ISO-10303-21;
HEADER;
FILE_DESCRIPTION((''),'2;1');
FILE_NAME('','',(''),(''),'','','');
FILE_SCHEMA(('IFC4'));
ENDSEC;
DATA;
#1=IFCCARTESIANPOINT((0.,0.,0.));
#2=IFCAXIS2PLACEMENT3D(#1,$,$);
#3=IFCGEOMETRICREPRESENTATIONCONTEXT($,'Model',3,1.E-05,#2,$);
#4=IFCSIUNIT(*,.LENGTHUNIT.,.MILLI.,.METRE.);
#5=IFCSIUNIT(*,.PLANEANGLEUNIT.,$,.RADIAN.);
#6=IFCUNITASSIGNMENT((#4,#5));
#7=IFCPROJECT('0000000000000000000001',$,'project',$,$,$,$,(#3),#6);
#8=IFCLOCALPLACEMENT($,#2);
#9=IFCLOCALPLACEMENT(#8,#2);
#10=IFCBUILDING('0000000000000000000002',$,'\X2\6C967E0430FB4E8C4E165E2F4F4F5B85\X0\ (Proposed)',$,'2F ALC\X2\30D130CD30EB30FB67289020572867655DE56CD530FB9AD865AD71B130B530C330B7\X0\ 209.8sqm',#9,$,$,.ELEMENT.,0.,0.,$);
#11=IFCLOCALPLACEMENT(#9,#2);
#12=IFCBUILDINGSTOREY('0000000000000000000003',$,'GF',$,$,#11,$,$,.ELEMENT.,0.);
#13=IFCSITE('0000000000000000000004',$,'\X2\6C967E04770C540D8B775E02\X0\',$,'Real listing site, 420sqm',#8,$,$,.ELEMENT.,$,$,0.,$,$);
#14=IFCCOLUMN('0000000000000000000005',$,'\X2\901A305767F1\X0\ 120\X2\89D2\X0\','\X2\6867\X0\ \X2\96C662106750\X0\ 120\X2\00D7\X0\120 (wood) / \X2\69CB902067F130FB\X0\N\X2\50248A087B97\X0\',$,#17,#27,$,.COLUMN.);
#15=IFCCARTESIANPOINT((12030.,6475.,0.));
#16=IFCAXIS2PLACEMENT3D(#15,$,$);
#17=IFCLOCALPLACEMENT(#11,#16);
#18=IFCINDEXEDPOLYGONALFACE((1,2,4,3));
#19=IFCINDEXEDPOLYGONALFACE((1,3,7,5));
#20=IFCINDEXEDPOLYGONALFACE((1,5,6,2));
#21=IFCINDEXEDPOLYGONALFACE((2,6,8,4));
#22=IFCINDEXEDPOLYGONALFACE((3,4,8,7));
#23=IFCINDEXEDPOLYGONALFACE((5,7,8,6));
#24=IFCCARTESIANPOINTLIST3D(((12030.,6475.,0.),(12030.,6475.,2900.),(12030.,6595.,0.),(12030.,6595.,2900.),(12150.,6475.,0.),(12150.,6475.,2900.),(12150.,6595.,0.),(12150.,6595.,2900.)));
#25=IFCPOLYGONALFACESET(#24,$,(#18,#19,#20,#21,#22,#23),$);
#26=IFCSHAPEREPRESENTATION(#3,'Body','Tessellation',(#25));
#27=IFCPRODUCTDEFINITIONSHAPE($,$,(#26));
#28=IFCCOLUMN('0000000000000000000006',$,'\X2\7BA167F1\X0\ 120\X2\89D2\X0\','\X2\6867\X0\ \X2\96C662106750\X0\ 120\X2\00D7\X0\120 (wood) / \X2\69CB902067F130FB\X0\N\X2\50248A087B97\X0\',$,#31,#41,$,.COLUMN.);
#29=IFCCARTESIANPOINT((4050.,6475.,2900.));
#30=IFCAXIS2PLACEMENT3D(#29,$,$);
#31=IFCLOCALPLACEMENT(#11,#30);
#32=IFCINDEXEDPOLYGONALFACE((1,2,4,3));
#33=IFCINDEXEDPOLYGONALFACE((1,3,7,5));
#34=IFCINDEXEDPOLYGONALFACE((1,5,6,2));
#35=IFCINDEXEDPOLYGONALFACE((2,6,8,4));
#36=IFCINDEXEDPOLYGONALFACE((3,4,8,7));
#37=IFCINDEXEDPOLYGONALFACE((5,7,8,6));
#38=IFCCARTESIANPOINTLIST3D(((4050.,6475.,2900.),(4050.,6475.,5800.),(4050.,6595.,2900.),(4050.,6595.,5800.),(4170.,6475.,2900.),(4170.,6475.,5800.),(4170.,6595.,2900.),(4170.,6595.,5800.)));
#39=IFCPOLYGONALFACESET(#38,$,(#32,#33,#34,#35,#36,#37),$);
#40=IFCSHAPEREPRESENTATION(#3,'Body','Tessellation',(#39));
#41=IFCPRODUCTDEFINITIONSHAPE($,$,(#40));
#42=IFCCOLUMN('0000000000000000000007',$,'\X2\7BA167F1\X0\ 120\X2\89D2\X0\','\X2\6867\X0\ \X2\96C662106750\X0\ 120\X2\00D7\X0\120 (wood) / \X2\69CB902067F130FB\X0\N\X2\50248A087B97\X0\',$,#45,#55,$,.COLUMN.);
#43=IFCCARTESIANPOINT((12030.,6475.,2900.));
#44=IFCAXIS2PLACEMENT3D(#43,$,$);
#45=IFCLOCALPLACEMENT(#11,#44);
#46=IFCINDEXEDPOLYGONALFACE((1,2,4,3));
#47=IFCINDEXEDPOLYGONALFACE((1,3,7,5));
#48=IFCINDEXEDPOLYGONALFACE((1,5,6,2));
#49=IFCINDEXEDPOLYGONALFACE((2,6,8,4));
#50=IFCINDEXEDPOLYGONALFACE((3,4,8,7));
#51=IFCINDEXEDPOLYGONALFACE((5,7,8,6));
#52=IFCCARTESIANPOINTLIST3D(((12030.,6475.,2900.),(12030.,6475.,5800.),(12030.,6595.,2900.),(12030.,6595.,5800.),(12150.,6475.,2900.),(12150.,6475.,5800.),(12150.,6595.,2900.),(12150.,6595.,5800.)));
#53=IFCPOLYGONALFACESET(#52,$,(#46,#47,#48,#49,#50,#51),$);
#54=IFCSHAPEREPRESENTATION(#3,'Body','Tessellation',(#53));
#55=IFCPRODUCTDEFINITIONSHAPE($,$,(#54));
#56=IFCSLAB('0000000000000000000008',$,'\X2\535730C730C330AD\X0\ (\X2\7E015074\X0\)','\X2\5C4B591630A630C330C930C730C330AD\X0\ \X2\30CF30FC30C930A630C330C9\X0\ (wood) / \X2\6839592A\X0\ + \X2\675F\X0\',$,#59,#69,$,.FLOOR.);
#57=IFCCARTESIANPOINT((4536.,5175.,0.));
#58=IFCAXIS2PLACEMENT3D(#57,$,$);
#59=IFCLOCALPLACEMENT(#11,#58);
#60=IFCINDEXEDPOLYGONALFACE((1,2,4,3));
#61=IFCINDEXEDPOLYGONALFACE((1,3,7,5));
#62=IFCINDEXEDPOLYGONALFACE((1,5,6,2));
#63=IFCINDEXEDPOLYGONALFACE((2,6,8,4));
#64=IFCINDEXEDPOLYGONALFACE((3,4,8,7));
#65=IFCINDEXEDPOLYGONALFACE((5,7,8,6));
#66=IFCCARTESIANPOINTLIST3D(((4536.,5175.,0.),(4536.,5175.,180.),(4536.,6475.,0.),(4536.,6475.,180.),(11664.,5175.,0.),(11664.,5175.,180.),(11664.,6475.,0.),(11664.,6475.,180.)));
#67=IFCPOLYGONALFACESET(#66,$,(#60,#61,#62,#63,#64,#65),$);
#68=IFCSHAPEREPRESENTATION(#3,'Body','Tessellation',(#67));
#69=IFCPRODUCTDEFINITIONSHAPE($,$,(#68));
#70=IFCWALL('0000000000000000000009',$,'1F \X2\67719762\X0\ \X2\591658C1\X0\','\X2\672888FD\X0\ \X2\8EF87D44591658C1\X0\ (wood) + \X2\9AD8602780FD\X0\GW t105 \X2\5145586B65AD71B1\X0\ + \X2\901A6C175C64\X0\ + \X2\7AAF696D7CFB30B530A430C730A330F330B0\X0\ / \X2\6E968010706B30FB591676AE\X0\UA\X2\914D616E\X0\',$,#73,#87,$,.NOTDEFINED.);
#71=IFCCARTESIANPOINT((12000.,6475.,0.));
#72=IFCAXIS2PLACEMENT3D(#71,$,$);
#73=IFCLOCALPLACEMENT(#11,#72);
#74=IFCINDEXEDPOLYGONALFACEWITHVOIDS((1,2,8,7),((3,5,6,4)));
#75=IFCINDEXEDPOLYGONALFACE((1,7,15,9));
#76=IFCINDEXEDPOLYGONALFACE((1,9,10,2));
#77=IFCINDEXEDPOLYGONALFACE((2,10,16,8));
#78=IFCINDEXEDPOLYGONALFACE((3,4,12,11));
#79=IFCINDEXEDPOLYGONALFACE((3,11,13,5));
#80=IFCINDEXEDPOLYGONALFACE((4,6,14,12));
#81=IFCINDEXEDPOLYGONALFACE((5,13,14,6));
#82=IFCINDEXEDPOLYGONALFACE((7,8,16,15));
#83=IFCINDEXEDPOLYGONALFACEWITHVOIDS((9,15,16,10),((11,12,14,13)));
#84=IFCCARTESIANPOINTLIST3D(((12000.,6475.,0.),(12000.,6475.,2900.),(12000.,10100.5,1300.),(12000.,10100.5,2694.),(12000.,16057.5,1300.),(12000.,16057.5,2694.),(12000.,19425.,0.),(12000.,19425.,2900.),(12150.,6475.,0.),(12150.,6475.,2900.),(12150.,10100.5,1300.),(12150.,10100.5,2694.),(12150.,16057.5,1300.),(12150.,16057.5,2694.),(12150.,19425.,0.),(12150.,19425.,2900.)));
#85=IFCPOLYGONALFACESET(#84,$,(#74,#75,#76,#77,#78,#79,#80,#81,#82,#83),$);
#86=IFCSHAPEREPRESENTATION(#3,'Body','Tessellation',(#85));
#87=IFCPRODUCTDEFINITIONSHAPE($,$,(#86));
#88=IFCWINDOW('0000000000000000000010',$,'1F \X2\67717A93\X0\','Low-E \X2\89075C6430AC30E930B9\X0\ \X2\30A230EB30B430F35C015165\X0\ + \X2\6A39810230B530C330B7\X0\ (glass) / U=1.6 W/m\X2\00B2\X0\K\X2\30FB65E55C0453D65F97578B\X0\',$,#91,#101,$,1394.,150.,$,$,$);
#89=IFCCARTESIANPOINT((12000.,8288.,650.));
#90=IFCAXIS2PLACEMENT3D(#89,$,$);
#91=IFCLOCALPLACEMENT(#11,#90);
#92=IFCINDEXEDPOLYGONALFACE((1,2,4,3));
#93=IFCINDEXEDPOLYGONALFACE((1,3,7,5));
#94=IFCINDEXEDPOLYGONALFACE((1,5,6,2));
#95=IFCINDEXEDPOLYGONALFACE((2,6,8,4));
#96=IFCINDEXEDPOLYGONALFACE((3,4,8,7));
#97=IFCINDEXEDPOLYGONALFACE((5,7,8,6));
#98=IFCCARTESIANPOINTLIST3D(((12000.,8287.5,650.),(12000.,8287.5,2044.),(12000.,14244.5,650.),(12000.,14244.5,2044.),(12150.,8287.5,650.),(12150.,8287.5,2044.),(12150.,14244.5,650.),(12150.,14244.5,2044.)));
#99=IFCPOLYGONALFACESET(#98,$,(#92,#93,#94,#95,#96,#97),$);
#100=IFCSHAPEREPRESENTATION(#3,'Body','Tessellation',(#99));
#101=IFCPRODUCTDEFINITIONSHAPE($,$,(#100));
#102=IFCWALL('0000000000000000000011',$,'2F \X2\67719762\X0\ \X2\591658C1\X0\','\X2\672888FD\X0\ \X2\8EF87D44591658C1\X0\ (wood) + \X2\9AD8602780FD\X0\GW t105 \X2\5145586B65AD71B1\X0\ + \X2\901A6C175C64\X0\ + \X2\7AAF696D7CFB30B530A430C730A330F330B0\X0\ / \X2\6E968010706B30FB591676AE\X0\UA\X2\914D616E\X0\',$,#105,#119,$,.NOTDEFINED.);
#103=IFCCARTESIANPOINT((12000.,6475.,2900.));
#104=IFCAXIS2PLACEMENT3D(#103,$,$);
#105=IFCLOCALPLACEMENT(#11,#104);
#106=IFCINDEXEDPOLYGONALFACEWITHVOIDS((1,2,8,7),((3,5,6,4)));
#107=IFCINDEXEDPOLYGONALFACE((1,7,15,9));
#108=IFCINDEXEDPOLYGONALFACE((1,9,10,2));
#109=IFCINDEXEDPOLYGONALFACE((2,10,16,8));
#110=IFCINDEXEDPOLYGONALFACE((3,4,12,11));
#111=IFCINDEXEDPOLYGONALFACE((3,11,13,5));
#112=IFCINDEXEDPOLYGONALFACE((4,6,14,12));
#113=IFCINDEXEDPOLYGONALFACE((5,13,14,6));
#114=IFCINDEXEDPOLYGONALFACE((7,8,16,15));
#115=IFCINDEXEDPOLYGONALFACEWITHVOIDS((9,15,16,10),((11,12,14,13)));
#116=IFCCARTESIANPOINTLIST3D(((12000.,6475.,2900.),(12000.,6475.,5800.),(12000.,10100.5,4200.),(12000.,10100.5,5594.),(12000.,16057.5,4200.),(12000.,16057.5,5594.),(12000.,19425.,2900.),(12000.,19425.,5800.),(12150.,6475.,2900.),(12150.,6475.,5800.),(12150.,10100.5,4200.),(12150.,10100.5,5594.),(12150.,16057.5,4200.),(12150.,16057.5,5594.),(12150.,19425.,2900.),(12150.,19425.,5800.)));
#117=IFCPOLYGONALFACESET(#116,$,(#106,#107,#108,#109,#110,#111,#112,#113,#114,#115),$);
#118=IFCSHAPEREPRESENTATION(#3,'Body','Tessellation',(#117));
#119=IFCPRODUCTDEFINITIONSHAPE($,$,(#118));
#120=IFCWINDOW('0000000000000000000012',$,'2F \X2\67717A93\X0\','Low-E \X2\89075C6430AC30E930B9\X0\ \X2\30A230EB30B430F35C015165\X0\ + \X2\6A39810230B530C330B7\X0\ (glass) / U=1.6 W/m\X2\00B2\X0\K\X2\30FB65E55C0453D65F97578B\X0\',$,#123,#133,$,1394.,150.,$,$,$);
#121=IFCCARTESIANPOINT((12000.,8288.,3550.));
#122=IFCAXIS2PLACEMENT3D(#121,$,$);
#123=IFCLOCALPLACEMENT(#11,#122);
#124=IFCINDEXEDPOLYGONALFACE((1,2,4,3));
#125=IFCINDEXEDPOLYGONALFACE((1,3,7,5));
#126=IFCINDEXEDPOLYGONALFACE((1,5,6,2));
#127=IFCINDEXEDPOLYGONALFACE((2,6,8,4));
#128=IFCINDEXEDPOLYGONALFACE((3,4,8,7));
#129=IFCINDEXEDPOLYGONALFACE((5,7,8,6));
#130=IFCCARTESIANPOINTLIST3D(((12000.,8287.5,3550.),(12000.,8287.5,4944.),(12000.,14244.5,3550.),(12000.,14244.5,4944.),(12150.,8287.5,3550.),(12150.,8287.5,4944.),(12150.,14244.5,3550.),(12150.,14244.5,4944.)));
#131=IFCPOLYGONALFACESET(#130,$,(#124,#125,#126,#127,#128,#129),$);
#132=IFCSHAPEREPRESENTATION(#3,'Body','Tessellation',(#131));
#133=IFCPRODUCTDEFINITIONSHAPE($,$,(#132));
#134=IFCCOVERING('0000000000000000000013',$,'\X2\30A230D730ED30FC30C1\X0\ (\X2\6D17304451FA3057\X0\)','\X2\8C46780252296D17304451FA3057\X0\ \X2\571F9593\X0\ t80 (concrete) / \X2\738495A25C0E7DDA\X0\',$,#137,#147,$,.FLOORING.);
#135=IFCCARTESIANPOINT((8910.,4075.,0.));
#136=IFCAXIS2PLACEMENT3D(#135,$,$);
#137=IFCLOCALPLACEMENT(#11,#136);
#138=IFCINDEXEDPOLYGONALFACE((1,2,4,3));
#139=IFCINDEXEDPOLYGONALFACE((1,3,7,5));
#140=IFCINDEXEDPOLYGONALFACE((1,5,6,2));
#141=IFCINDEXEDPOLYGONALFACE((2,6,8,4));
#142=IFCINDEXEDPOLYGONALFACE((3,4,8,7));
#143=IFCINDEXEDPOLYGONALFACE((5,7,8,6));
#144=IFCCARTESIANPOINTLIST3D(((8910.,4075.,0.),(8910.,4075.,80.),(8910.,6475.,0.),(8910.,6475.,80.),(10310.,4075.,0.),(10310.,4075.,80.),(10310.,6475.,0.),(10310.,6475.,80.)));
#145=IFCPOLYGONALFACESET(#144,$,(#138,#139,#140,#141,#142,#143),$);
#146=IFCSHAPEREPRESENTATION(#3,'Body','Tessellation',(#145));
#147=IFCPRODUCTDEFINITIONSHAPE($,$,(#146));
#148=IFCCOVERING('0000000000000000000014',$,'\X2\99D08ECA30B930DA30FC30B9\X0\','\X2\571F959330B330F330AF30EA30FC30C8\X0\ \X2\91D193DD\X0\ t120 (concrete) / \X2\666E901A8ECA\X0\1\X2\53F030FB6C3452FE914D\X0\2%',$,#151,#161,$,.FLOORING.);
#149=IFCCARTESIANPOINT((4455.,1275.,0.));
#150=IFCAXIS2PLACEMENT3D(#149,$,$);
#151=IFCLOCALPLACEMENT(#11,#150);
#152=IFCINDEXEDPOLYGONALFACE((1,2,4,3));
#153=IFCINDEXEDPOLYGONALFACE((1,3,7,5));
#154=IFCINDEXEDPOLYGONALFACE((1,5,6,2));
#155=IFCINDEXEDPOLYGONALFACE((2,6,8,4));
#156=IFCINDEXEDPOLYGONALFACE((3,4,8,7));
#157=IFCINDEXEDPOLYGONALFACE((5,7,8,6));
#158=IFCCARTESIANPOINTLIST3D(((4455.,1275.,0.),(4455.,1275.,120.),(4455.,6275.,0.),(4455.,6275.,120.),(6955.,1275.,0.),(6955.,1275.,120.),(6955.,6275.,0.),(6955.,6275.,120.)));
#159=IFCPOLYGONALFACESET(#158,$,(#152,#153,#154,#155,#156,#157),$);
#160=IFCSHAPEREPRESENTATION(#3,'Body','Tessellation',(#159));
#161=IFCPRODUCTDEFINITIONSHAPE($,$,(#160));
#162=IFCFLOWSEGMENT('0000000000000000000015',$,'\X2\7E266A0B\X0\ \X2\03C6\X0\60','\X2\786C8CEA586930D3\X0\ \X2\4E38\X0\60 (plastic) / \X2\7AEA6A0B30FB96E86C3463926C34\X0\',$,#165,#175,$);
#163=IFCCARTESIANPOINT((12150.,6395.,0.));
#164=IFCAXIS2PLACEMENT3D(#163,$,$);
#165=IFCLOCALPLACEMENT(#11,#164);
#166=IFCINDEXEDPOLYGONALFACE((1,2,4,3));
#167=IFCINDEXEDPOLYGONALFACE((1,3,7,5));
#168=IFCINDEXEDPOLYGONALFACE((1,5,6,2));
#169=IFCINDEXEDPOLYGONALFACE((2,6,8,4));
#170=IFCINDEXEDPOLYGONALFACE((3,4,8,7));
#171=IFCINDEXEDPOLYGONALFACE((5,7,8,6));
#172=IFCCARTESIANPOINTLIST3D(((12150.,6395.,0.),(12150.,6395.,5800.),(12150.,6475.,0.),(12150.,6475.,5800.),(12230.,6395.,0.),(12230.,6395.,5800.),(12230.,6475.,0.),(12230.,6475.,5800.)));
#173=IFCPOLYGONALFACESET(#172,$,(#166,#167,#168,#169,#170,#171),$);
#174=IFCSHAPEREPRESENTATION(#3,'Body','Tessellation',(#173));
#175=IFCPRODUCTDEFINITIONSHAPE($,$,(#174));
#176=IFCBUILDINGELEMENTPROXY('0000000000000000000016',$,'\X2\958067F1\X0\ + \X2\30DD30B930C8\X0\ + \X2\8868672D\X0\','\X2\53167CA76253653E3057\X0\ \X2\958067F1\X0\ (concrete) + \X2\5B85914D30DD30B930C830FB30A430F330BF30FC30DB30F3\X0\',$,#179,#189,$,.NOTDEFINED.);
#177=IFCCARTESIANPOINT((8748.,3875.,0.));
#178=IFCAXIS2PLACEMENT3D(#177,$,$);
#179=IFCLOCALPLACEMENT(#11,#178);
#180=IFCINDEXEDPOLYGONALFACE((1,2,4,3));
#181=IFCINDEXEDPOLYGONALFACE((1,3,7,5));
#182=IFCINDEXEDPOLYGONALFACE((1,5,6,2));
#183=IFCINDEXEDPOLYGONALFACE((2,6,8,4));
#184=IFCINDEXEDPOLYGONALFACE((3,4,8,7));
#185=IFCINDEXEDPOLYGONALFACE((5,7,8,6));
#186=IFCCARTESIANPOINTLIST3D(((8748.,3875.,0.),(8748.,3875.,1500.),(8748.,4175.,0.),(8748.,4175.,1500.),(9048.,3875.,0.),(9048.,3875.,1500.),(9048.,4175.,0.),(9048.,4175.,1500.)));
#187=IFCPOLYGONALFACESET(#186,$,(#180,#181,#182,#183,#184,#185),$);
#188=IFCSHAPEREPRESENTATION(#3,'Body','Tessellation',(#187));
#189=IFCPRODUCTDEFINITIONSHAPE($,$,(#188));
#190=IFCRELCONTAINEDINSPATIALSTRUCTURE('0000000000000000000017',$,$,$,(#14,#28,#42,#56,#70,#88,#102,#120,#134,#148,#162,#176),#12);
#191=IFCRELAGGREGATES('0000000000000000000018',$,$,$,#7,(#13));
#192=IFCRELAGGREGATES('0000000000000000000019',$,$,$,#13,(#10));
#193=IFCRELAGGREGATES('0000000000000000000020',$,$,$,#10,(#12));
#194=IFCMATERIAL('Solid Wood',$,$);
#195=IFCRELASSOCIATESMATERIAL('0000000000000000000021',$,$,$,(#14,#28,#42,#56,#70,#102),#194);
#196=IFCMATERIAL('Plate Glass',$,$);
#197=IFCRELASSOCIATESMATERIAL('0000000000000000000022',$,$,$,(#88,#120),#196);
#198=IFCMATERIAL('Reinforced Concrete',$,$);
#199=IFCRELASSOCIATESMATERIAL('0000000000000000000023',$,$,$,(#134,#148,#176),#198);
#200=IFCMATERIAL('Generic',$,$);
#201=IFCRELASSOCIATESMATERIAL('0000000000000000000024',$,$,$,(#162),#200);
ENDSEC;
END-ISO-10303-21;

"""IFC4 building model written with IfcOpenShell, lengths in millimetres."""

from ifc_helpers import new_model, si_unit, frame, frame_2d, origin, place, context, project, spatial, rectangle, extrude, material, element, fill, save


model = new_model("IFC4")

# Units and contexts
model_context = context("Model", 3, precision=1e-05, world=origin())
ifc_project = project(units=[si_unit("LENGTHUNIT", "METRE", prefix="MILLI"), si_unit("PLANEANGLEUNIT", "RADIAN")], contexts=[model_context])

# Site, building, storey
site_placement = place(None, origin())
site = spatial("IfcSite", under=ifc_project, at=site_placement, Name="沖縄県名護市", ObjectType="Real listing site, 420sqm", CompositionType="ELEMENT", RefElevation=0.0)
building_placement = place(site_placement, origin())
building = spatial("IfcBuilding", under=site, at=building_placement, Name="沖縄・二世帯住宅 (Proposed)", ObjectType="2F ALCパネル・木造在来工法・高断熱サッシ 209.8sqm", CompositionType="ELEMENT", ElevationOfRefHeight=0.0, ElevationOfTerrain=0.0)
storey_placement = place(building_placement, origin())
storey = spatial("IfcBuildingStorey", under=building, at=storey_placement, Name="GF", CompositionType="ELEMENT", Elevation=0.0)

# Columns
ifc_material_1 = material(Name="Solid Wood")
column_1_placement = place(storey_placement, frame((12030.0, 6475.0, 0.0)))
element("IfcColumn", 1, at=column_1_placement, inside=storey, material=ifc_material_1, Name="通し柱 120角", Description="桧 集成材 120×120 (wood) / 構造柱・N値計算", PredefinedType="COLUMN", context=model_context, shape_type="SweptSolid", body=[
    extrude(rectangle(XDim=120.0, YDim=120.0, at=frame_2d((60.0, 60.0))), frame((12030.0, 6475.0, 0.0)), (0.0, 0.0, 1.0), 2900.0),
])
column_2_placement = place(storey_placement, frame((4050.0, 6475.0, 2900.0)))
element("IfcColumn", 2, at=column_2_placement, inside=storey, material=ifc_material_1, Name="管柱 120角", Description="桧 集成材 120×120 (wood) / 構造柱・N値計算", PredefinedType="COLUMN", context=model_context, shape_type="SweptSolid", body=[
    extrude(rectangle(XDim=120.0, YDim=120.0, at=frame_2d((60.0, 60.0))), frame((4050.0, 6475.0, 2900.0)), (0.0, 0.0, 1.0), 2900.0),
])
column_3_placement = place(storey_placement, frame((12030.0, 6475.0, 2900.0)))
element("IfcColumn", 3, at=column_3_placement, inside=storey, material=ifc_material_1, Name="管柱 120角", Description="桧 集成材 120×120 (wood) / 構造柱・N値計算", PredefinedType="COLUMN", context=model_context, shape_type="SweptSolid", body=[
    extrude(rectangle(XDim=120.0, YDim=120.0, at=frame_2d((60.0, 60.0))), frame((12030.0, 6475.0, 2900.0)), (0.0, 0.0, 1.0), 2900.0),
])

# Slab
slab_placement = place(storey_placement, frame((4536.0, 5175.0, 0.0)))
element("IfcSlab", 4, at=slab_placement, inside=storey, material=ifc_material_1, Name="南デッキ (縁側)", Description="屋外ウッドデッキ ハードウッド (wood) / 根太 + 束", PredefinedType="FLOOR", context=model_context, shape_type="SweptSolid", body=[
    extrude(rectangle(XDim=7128.0, YDim=1300.0, at=frame_2d((3564.0, 650.0))), frame((4536.0, 5175.0, 0.0)), (0.0, 0.0, 1.0), 180.0),
])

# Walls, openings, windows
wall_1_placement = place(storey_placement, frame((12000.0, 6475.0, 0.0)))
wall_1 = element("IfcWall", 5, at=wall_1_placement, inside=storey, material=ifc_material_1, Name="1F 東面 外壁", Description="木製 軸組外壁 (wood) + 高性能GW t105 充填断熱 + 通気層 + 窯業系サイディング / 準耐火・外皮UA配慮", PredefinedType="NOTDEFINED", context=model_context, shape_type="SweptSolid", body=[
    extrude(rectangle(XDim=150.0, YDim=12950.0, at=frame_2d((75.0, 6475.0))), frame((12000.0, 6475.0, 0.0)), (0.0, 0.0, 1.0), 2900.0),
])
opening_1_placement = place(storey_placement, frame((12000.0, 8288.0, 650.0)))
opening_1 = element("IfcOpeningElement", 6, at=opening_1_placement, cuts=wall_1, PredefinedType="NOTDEFINED", context=model_context, shape_type="SweptSolid", body=[
    extrude(rectangle(XDim=150.0, YDim=5957.0, at=frame_2d((75.0, 2978.0))), frame((12000.0, 8288.0, 650.0)), (0.0, 0.0, 1.0), 1394.0),
])
ifc_material_2 = material(Name="Plate Glass")
window_1_placement = place(storey_placement, frame((12000.0, 8288.0, 650.0)))
window_1 = element("IfcWindow", 7, at=window_1_placement, inside=storey, material=ifc_material_2, Name="1F 東窓", Description="Low-E 複層ガラス アルゴン封入 + 樹脂サッシ (glass) / U=1.6 W/m²K・日射取得型", OverallHeight=1394.0, OverallWidth=150.0, context=model_context, shape_type="SweptSolid", body=[
    extrude(rectangle(XDim=150.0, YDim=5957.0, at=frame_2d((75.0, 2978.0))), frame((12000.0, 8288.0, 650.0)), (0.0, 0.0, 1.0), 1394.0),
])
fill(opening_1, window_1)
wall_2_placement = place(storey_placement, frame((12000.0, 6475.0, 2900.0)))
wall_2 = element("IfcWall", 8, at=wall_2_placement, inside=storey, material=ifc_material_1, Name="2F 東面 外壁", Description="木製 軸組外壁 (wood) + 高性能GW t105 充填断熱 + 通気層 + 窯業系サイディング / 準耐火・外皮UA配慮", PredefinedType="NOTDEFINED", context=model_context, shape_type="SweptSolid", body=[
    extrude(rectangle(XDim=150.0, YDim=12950.0, at=frame_2d((75.0, 6475.0))), frame((12000.0, 6475.0, 2900.0)), (0.0, 0.0, 1.0), 2900.0),
])
opening_2_placement = place(storey_placement, frame((12000.0, 8288.0, 3550.0)))
opening_2 = element("IfcOpeningElement", 9, at=opening_2_placement, cuts=wall_2, PredefinedType="NOTDEFINED", context=model_context, shape_type="SweptSolid", body=[
    extrude(rectangle(XDim=150.0, YDim=5957.0, at=frame_2d((75.0, 2978.0))), frame((12000.0, 8288.0, 3550.0)), (0.0, 0.0, 1.0), 1394.0),
])
window_2_placement = place(storey_placement, frame((12000.0, 8288.0, 3550.0)))
window_2 = element("IfcWindow", 10, at=window_2_placement, inside=storey, material=ifc_material_2, Name="2F 東窓", Description="Low-E 複層ガラス アルゴン封入 + 樹脂サッシ (glass) / U=1.6 W/m²K・日射取得型", OverallHeight=1394.0, OverallWidth=150.0, context=model_context, shape_type="SweptSolid", body=[
    extrude(rectangle(XDim=150.0, YDim=5957.0, at=frame_2d((75.0, 2978.0))), frame((12000.0, 8288.0, 3550.0)), (0.0, 0.0, 1.0), 1394.0),
])
fill(opening_2, window_2)

# Coverings
ifc_material_3 = material(Name="Reinforced Concrete")
covering_1_placement = place(storey_placement, frame((8910.0, 4075.0, 0.0)))
element("IfcCovering", 11, at=covering_1_placement, inside=storey, material=ifc_material_3, Name="アプローチ (洗い出し)", Description="豆砂利洗い出し 土間 t80 (concrete) / 玄関導線", PredefinedType="FLOORING", context=model_context, shape_type="SweptSolid", body=[
    extrude(rectangle(XDim=1400.0, YDim=2400.0, at=frame_2d((700.0, 1200.0))), frame((8910.0, 4075.0, 0.0)), (0.0, 0.0, 1.0), 80.0),
])
covering_2_placement = place(storey_placement, frame((4455.0, 1275.0, 0.0)))
element("IfcCovering", 12, at=covering_2_placement, inside=storey, material=ifc_material_3, Name="駐車スペース", Description="土間コンクリート 金鏝 t120 (concrete) / 普通車1台・水勾配2%", PredefinedType="FLOORING", context=model_context, shape_type="SweptSolid", body=[
    extrude(rectangle(XDim=2500.0, YDim=5000.0, at=frame_2d((1250.0, 2500.0))), frame((4455.0, 1275.0, 0.0)), (0.0, 0.0, 1.0), 120.0),
])

# Flow segment
ifc_material_4 = material(Name="Generic")
flow_segment_placement = place(storey_placement, frame((12150.0, 6395.0, 0.0)))
element("IfcFlowSegment", 13, at=flow_segment_placement, inside=storey, material=ifc_material_4, Name="縦樋 φ60", Description="硬質塩ビ 丸60 (plastic) / 竪樋・雨水排水", context=model_context, shape_type="SweptSolid", body=[
    extrude(rectangle(XDim=80.0, YDim=80.0, at=frame_2d((40.0, 40.0))), frame((12150.0, 6395.0, 0.0)), (0.0, 0.0, 1.0), 5800.0),
])

# Building element proxy
proxy_placement = place(storey_placement, frame((8748.0, 3875.0, 0.0)))
element("IfcBuildingElementProxy", 14, at=proxy_placement, inside=storey, material=ifc_material_3, Name="門柱 + ポスト + 表札", Description="化粧打放し 門柱 (concrete) + 宅配ポスト・インターホン", PredefinedType="NOTDEFINED", context=model_context, shape_type="SweptSolid", body=[
    extrude(rectangle(XDim=300.0, YDim=300.0, at=frame_2d((150.0, 150.0))), frame((8748.0, 3875.0, 0.0)), (0.0, 0.0, 1.0), 1500.0),
])

save(model, "model.ifc")
